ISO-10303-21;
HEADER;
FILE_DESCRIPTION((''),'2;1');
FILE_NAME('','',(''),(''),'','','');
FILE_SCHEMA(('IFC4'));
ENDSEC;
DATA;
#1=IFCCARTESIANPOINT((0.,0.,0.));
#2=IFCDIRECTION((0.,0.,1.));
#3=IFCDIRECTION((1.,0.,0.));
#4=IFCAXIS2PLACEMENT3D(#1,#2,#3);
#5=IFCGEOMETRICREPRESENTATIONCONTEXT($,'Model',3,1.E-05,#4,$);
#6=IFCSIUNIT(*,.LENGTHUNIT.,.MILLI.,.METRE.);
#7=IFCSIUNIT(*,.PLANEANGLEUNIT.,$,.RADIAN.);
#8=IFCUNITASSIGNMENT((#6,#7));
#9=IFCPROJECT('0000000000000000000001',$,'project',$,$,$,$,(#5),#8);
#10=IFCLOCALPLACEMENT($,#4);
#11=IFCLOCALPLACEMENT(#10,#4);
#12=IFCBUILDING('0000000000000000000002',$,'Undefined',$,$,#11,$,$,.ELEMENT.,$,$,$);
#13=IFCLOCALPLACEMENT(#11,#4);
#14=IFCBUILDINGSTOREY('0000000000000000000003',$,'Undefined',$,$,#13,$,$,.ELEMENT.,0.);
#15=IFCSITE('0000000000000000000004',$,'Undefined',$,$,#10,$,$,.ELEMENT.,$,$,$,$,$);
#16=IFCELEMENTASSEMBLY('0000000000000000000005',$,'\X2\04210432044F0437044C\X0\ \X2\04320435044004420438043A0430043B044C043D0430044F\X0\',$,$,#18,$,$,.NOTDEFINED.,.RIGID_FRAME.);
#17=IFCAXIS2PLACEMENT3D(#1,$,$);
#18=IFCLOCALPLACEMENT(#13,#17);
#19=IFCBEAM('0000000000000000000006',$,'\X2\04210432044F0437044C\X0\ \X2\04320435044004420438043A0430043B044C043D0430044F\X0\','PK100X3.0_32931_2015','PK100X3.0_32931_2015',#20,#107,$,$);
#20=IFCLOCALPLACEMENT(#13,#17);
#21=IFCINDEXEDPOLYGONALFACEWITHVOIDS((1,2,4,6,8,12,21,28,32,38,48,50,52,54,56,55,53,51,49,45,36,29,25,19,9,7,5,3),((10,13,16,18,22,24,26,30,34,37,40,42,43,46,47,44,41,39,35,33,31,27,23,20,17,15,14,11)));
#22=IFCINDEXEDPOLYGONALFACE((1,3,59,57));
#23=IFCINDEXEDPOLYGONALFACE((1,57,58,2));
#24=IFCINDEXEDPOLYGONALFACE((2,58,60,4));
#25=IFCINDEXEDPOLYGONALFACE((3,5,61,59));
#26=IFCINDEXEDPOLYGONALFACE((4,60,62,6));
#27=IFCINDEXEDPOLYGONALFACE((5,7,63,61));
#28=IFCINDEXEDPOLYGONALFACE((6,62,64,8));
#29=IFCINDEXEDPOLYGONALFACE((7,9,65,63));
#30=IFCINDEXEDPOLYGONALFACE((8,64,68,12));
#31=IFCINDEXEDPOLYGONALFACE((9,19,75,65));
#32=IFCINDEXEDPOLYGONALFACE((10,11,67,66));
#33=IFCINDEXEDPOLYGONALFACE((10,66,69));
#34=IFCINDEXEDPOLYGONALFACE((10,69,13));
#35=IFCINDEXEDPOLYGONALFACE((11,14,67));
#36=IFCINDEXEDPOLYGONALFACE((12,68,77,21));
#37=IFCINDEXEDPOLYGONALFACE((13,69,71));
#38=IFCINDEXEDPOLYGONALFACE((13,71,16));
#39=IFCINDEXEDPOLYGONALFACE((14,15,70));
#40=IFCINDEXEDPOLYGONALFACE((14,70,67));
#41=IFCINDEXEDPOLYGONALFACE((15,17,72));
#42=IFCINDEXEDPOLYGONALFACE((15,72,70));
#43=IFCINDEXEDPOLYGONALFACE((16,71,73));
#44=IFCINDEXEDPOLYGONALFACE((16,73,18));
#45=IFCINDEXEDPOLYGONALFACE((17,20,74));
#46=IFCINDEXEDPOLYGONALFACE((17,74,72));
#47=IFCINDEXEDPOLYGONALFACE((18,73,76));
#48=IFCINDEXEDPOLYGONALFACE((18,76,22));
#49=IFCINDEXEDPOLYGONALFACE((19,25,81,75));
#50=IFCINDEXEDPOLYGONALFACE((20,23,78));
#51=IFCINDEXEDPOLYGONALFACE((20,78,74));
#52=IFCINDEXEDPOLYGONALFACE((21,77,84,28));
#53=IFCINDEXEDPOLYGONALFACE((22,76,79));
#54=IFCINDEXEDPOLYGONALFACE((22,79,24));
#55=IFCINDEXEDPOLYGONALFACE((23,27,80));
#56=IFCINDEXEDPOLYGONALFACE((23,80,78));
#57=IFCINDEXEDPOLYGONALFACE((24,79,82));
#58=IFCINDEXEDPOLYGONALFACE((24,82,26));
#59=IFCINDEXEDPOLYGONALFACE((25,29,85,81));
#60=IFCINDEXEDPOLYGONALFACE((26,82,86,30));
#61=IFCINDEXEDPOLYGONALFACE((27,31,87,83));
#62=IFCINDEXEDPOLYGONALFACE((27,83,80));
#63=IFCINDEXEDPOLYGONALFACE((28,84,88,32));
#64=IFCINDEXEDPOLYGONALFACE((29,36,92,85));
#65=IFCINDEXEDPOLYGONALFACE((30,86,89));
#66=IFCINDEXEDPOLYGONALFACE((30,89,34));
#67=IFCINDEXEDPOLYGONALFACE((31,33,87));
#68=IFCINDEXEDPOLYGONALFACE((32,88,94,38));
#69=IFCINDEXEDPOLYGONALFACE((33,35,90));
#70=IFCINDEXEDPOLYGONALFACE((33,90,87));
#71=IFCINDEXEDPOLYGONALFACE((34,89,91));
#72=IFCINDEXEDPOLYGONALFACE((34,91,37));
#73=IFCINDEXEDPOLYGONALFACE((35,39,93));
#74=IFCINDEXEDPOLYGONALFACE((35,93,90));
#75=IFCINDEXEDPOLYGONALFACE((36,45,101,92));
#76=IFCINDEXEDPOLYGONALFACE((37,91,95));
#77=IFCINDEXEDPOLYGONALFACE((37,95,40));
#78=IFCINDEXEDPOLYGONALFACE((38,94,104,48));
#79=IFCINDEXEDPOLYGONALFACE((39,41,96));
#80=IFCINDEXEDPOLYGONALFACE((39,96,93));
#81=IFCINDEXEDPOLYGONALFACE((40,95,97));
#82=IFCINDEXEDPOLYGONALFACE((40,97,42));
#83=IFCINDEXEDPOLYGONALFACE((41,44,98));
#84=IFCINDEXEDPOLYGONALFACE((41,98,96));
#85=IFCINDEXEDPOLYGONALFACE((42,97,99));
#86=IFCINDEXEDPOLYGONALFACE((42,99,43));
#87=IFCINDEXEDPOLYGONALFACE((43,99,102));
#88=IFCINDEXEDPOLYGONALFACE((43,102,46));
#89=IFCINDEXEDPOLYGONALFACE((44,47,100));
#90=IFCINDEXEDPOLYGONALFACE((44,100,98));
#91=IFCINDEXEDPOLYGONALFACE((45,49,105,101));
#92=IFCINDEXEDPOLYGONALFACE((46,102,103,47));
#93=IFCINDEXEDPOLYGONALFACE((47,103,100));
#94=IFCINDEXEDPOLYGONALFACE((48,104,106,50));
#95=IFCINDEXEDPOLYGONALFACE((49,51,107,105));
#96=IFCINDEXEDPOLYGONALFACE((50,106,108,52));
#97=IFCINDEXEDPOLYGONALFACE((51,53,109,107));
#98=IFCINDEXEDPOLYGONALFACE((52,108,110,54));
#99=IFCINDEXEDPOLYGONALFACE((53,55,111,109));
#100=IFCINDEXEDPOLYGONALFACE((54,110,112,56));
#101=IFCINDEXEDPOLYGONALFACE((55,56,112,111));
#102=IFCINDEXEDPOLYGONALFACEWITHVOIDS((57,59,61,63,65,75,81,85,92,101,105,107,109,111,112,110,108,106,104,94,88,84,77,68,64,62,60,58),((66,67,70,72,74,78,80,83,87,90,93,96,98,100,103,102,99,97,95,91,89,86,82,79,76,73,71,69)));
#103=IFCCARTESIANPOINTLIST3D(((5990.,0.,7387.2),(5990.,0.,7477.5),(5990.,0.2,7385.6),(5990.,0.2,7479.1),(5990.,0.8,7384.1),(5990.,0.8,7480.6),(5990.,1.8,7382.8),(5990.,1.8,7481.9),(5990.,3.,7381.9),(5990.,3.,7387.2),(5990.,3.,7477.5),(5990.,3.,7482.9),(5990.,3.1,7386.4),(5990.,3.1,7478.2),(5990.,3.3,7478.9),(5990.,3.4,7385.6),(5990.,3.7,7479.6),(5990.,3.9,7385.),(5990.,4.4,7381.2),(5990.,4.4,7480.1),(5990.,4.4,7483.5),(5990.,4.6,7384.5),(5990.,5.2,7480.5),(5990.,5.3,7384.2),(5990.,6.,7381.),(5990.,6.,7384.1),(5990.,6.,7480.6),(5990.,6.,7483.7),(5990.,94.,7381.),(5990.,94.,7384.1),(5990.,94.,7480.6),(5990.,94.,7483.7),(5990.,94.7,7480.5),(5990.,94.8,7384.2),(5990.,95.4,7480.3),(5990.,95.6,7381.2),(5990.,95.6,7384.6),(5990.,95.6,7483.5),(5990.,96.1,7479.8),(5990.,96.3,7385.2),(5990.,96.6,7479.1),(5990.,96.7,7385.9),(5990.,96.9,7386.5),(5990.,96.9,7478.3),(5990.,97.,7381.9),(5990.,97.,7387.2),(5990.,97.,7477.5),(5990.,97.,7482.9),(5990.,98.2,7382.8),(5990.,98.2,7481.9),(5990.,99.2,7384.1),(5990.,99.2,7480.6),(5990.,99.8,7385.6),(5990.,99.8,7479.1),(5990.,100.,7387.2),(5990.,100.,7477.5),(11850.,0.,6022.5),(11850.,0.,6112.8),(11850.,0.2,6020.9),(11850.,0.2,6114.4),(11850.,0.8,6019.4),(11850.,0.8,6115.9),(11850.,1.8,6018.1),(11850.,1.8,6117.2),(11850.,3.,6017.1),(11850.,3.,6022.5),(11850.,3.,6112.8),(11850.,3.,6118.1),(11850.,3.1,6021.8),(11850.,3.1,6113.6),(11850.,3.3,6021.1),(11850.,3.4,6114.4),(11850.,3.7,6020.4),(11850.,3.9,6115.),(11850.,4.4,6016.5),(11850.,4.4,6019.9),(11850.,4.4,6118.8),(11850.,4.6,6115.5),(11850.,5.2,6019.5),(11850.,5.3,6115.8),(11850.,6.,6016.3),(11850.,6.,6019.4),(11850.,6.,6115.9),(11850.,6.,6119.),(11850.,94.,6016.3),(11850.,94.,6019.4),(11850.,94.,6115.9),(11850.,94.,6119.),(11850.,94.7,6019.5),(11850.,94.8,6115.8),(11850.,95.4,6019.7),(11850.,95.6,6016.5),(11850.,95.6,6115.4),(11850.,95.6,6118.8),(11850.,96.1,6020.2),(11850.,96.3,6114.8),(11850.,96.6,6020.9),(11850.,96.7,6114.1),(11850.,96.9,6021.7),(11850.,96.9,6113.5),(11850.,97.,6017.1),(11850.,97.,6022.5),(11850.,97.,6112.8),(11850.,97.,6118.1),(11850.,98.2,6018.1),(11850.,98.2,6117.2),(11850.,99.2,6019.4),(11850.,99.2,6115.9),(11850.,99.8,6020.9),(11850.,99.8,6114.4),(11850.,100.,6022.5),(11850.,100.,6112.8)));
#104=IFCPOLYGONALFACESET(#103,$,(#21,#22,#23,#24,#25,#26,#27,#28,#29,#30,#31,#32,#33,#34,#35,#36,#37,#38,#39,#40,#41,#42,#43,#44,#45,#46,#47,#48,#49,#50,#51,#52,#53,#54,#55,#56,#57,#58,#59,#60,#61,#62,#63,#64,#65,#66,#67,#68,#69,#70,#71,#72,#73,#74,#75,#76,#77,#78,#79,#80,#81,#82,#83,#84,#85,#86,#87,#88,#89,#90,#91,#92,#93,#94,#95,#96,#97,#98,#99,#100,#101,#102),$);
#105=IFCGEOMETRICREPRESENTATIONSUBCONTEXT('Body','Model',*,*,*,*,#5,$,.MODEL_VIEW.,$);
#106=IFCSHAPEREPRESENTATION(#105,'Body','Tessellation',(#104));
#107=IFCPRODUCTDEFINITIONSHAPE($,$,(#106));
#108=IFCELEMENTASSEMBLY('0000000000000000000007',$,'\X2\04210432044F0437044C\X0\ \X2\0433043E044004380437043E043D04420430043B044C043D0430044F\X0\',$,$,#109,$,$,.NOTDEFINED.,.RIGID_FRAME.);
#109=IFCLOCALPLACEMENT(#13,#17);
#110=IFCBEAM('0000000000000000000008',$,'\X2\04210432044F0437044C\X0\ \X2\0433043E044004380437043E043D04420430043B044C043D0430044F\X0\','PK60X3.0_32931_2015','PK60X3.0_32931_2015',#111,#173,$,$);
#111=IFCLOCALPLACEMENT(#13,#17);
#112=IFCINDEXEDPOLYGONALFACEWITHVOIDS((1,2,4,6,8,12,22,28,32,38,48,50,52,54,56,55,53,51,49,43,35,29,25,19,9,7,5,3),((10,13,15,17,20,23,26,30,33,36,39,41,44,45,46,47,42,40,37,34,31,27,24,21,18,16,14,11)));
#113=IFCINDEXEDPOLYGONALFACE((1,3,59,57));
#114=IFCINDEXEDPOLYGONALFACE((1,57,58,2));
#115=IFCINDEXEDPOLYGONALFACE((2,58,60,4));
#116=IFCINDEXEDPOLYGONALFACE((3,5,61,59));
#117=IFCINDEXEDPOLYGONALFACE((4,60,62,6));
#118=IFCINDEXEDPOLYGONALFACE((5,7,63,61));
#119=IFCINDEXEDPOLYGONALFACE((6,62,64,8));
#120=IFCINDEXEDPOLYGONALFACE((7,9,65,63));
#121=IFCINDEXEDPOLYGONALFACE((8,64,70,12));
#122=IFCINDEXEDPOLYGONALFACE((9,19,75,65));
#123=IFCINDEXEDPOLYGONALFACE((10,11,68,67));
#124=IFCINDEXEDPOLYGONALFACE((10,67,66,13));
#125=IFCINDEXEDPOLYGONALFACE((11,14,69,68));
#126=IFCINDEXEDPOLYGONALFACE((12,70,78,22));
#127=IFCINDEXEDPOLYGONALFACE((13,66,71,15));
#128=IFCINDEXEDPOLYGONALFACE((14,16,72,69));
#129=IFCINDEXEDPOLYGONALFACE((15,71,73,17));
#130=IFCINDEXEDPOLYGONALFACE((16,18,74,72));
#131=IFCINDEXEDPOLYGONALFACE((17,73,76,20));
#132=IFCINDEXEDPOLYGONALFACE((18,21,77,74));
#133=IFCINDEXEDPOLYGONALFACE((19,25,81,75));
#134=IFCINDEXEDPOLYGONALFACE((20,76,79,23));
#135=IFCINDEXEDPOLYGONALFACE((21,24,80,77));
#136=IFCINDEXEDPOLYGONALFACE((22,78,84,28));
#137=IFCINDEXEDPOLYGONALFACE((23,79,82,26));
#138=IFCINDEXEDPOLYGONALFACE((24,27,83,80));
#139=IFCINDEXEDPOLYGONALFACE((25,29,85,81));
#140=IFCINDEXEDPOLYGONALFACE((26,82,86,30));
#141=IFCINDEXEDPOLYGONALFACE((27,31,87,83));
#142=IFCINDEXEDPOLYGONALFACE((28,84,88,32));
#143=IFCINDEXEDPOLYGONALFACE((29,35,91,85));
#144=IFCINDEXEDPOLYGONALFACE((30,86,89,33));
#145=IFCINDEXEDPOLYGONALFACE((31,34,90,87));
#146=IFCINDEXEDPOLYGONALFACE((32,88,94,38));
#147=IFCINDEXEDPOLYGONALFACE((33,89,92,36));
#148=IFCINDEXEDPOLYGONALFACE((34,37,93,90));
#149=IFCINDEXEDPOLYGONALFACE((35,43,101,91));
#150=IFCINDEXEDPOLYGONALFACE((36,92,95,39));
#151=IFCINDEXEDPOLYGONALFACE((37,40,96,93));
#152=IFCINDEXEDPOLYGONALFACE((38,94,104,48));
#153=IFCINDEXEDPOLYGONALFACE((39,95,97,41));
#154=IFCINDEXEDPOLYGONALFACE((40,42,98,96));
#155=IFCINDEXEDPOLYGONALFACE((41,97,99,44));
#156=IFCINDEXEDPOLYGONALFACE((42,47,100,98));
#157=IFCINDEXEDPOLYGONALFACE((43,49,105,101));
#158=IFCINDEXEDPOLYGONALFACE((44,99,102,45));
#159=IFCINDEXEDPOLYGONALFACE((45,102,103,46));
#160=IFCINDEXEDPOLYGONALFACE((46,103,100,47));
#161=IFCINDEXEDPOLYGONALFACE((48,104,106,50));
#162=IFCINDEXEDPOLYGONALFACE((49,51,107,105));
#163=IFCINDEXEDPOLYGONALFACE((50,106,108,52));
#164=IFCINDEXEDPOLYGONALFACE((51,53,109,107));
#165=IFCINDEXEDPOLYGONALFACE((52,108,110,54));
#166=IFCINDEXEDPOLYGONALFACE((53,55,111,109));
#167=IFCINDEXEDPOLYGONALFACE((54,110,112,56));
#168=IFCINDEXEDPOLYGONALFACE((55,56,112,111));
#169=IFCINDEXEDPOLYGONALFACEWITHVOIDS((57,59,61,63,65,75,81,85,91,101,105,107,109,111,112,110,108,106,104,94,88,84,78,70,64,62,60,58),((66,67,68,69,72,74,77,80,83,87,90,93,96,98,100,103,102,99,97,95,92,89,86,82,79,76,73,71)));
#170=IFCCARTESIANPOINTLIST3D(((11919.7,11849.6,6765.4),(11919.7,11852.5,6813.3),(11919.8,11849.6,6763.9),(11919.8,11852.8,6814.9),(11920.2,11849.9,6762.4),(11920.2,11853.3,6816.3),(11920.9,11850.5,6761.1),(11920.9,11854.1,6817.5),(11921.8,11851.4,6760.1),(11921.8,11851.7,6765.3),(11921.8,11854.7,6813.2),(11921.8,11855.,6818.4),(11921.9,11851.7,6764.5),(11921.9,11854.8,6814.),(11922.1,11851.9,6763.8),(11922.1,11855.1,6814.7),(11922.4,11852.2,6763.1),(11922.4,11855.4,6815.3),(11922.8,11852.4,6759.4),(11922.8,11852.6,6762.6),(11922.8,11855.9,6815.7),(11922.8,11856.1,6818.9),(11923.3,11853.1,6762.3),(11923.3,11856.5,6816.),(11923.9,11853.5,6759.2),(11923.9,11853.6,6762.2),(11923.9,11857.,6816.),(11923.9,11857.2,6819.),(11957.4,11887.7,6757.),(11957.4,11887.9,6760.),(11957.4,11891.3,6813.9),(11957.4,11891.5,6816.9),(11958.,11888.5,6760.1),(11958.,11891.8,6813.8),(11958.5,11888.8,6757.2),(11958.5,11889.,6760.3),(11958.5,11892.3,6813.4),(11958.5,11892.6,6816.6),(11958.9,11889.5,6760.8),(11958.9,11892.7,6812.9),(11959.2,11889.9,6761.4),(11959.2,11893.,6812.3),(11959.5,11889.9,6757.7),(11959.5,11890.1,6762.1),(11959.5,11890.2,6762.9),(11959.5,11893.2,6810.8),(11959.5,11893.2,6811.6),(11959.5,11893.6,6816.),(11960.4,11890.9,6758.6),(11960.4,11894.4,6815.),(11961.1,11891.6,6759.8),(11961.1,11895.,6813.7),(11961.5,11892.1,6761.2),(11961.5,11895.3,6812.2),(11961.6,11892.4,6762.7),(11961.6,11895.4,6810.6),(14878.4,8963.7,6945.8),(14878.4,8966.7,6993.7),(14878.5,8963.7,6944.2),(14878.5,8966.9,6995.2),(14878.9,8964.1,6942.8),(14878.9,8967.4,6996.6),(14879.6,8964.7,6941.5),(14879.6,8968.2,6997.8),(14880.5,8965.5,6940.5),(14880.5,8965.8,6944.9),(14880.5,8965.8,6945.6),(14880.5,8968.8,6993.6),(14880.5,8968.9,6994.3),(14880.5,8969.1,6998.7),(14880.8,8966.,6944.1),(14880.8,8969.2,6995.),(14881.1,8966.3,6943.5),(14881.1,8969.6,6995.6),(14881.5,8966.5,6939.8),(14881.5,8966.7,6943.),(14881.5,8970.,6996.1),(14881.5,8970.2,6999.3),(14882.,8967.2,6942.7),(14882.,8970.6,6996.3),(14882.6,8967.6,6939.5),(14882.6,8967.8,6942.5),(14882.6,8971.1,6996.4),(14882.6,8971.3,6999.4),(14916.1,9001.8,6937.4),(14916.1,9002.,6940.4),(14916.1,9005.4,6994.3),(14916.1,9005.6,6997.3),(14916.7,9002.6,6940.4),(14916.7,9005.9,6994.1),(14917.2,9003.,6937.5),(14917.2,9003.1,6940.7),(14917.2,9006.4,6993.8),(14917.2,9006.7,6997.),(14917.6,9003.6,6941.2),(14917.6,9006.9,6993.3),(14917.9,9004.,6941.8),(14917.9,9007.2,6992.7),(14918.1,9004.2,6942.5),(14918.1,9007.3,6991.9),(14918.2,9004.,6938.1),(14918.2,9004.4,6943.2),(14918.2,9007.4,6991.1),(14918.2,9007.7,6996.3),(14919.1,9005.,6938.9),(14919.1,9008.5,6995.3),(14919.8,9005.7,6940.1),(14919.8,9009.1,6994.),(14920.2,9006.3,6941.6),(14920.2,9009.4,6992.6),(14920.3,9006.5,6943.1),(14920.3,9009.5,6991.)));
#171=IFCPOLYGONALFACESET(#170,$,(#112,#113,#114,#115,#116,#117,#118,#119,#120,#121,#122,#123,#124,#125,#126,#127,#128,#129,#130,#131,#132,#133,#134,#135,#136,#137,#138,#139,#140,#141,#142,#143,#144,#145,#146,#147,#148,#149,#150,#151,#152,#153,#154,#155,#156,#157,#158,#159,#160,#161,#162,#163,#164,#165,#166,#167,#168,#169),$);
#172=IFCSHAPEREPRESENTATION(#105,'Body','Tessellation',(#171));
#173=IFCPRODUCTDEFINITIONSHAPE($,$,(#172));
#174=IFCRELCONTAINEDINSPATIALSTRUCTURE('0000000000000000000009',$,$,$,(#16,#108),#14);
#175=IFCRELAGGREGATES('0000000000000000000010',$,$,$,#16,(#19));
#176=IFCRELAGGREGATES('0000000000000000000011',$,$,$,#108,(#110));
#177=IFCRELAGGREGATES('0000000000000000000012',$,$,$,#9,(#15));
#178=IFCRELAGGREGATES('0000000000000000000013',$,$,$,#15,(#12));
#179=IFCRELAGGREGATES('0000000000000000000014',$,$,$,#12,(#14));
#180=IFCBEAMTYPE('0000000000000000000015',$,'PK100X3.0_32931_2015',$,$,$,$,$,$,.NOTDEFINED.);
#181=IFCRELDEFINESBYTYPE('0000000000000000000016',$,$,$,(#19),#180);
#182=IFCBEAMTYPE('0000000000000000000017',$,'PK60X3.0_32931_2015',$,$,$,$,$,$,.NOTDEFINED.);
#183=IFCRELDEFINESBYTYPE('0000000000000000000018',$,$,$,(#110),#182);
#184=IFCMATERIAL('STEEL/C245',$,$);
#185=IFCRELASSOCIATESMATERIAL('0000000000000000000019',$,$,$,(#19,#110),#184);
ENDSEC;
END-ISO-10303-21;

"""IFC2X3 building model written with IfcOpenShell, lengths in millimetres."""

from ifc_helpers import new_model, si_unit, frame, origin_with_axes, origin_2d_with_axis, place, context, subcontext, project, spatial, hollow_rectangle, extrude, clip, halfspace, material, type_object, element, aggregate, save


model = new_model("IFC2X3")

# Units and contexts
model_context = context("Model", 3, precision=1e-05, world=origin_with_axes())
body_context = subcontext(model_context, "Body", "Model", "MODEL_VIEW")
ifc_project = project(units=[si_unit("LENGTHUNIT", "METRE", prefix="MILLI"), si_unit("PLANEANGLEUNIT", "RADIAN")], contexts=[model_context])

# Site, building, storey
site_placement = place(None, origin_with_axes())
site = spatial("IfcSite", under=ifc_project, at=site_placement, Name="Undefined", CompositionType="ELEMENT")
building_placement = place(site_placement, origin_with_axes())
building = spatial("IfcBuilding", under=site, at=building_placement, Name="Undefined", CompositionType="ELEMENT")
storey_placement = place(building_placement, origin_with_axes())
storey = spatial("IfcBuildingStorey", under=building, at=storey_placement, Name="Undefined", CompositionType="ELEMENT", Elevation=0.0)

# Shared definitions
ifc_material = material(Name="STEEL/C245")

# Element assemblies, beams
assembly_1_placement = place(storey_placement, origin_with_axes())
assembly_1 = element("IfcElementAssembly", 1, at=assembly_1_placement, inside=storey, Name="Связь вертикальная", AssemblyPlace="NOTDEFINED", PredefinedType="RIGID_FRAME")
beam_type_1 = type_object("IfcBeamType", Name="PK100X3.0_32931_2015", PredefinedType="NOTDEFINED")
beam_1_placement = place(assembly_1_placement, frame((11932.1, 50.0, 6048.5), z_axis=(0.22682, 0.0, 0.973937), x_axis=(-0.973937, 0.0, 0.22682)))
beam_1 = element("IfcBeam", 2, at=beam_1_placement, type_object=beam_type_1, material=ifc_material, Name="Связь вертикальная", Description="PK100X3.0_32931_2015", ObjectType="PK100X3.0_32931_2015", context=body_context, shape_type="Clipping", body=[
    clip(clip(extrude(hollow_rectangle(XDim=100.0, YDim=100.0, WallThickness=3.0, InnerFilletRadius=3.0, OuterFilletRadius=6.0, at=origin_2d_with_axis()), frame((6124.7, 0.0, 0.0), z_axis=(-1.0, 0.0, 0.0), x_axis=(0.0, -1.0, 0.0)), (0.0, 0.0, 1.0), 6063.9), halfspace(frame((6087.4, 50.0, -58.8), z_axis=(-0.973937, 0.0, 0.22682), x_axis=(-0.22682, 0.0, -0.973937)), True)), halfspace(frame((105.0, 50.0, 88.9), z_axis=(0.973937, 0.0, -0.22682), x_axis=(0.22682, 0.0, 0.973937)), True)),
])
aggregate(assembly_1, [beam_1])
assembly_2_placement = place(storey_placement, origin_with_axes())
assembly_2 = element("IfcElementAssembly", 3, at=assembly_2_placement, inside=storey, Name="Связь горизонтальная", AssemblyPlace="NOTDEFINED", PredefinedType="RIGID_FRAME")
beam_type_2 = type_object("IfcBeamType", Name="PK60X3.0_32931_2015", PredefinedType="NOTDEFINED")
beam_2_placement = place(assembly_2_placement, frame((11940.7, 11872.5, 6788.0), z_axis=(0.0, 0.062378, 0.998053), x_axis=(0.715179, -0.69758, 0.043599)))
beam_2 = element("IfcBeam", 4, at=beam_2_placement, type_object=beam_type_2, material=ifc_material, Name="Связь горизонтальная", Description="PK60X3.0_32931_2015", ObjectType="PK60X3.0_32931_2015", context=body_context, shape_type="SweptSolid", body=[
    extrude(hollow_rectangle(XDim=60.0, YDim=60.0, WallThickness=3.0, InnerFilletRadius=3.0, OuterFilletRadius=6.0, at=origin_2d_with_axis()), frame((4137.0, 0.0, 0.0), z_axis=(-1.0, 0.0, 0.0), x_axis=(0.0, -1.0, 0.0)), (0.0, 0.0, 1.0), 4137.0),
])
aggregate(assembly_2, [beam_2])

save(model, "model.ifc")
